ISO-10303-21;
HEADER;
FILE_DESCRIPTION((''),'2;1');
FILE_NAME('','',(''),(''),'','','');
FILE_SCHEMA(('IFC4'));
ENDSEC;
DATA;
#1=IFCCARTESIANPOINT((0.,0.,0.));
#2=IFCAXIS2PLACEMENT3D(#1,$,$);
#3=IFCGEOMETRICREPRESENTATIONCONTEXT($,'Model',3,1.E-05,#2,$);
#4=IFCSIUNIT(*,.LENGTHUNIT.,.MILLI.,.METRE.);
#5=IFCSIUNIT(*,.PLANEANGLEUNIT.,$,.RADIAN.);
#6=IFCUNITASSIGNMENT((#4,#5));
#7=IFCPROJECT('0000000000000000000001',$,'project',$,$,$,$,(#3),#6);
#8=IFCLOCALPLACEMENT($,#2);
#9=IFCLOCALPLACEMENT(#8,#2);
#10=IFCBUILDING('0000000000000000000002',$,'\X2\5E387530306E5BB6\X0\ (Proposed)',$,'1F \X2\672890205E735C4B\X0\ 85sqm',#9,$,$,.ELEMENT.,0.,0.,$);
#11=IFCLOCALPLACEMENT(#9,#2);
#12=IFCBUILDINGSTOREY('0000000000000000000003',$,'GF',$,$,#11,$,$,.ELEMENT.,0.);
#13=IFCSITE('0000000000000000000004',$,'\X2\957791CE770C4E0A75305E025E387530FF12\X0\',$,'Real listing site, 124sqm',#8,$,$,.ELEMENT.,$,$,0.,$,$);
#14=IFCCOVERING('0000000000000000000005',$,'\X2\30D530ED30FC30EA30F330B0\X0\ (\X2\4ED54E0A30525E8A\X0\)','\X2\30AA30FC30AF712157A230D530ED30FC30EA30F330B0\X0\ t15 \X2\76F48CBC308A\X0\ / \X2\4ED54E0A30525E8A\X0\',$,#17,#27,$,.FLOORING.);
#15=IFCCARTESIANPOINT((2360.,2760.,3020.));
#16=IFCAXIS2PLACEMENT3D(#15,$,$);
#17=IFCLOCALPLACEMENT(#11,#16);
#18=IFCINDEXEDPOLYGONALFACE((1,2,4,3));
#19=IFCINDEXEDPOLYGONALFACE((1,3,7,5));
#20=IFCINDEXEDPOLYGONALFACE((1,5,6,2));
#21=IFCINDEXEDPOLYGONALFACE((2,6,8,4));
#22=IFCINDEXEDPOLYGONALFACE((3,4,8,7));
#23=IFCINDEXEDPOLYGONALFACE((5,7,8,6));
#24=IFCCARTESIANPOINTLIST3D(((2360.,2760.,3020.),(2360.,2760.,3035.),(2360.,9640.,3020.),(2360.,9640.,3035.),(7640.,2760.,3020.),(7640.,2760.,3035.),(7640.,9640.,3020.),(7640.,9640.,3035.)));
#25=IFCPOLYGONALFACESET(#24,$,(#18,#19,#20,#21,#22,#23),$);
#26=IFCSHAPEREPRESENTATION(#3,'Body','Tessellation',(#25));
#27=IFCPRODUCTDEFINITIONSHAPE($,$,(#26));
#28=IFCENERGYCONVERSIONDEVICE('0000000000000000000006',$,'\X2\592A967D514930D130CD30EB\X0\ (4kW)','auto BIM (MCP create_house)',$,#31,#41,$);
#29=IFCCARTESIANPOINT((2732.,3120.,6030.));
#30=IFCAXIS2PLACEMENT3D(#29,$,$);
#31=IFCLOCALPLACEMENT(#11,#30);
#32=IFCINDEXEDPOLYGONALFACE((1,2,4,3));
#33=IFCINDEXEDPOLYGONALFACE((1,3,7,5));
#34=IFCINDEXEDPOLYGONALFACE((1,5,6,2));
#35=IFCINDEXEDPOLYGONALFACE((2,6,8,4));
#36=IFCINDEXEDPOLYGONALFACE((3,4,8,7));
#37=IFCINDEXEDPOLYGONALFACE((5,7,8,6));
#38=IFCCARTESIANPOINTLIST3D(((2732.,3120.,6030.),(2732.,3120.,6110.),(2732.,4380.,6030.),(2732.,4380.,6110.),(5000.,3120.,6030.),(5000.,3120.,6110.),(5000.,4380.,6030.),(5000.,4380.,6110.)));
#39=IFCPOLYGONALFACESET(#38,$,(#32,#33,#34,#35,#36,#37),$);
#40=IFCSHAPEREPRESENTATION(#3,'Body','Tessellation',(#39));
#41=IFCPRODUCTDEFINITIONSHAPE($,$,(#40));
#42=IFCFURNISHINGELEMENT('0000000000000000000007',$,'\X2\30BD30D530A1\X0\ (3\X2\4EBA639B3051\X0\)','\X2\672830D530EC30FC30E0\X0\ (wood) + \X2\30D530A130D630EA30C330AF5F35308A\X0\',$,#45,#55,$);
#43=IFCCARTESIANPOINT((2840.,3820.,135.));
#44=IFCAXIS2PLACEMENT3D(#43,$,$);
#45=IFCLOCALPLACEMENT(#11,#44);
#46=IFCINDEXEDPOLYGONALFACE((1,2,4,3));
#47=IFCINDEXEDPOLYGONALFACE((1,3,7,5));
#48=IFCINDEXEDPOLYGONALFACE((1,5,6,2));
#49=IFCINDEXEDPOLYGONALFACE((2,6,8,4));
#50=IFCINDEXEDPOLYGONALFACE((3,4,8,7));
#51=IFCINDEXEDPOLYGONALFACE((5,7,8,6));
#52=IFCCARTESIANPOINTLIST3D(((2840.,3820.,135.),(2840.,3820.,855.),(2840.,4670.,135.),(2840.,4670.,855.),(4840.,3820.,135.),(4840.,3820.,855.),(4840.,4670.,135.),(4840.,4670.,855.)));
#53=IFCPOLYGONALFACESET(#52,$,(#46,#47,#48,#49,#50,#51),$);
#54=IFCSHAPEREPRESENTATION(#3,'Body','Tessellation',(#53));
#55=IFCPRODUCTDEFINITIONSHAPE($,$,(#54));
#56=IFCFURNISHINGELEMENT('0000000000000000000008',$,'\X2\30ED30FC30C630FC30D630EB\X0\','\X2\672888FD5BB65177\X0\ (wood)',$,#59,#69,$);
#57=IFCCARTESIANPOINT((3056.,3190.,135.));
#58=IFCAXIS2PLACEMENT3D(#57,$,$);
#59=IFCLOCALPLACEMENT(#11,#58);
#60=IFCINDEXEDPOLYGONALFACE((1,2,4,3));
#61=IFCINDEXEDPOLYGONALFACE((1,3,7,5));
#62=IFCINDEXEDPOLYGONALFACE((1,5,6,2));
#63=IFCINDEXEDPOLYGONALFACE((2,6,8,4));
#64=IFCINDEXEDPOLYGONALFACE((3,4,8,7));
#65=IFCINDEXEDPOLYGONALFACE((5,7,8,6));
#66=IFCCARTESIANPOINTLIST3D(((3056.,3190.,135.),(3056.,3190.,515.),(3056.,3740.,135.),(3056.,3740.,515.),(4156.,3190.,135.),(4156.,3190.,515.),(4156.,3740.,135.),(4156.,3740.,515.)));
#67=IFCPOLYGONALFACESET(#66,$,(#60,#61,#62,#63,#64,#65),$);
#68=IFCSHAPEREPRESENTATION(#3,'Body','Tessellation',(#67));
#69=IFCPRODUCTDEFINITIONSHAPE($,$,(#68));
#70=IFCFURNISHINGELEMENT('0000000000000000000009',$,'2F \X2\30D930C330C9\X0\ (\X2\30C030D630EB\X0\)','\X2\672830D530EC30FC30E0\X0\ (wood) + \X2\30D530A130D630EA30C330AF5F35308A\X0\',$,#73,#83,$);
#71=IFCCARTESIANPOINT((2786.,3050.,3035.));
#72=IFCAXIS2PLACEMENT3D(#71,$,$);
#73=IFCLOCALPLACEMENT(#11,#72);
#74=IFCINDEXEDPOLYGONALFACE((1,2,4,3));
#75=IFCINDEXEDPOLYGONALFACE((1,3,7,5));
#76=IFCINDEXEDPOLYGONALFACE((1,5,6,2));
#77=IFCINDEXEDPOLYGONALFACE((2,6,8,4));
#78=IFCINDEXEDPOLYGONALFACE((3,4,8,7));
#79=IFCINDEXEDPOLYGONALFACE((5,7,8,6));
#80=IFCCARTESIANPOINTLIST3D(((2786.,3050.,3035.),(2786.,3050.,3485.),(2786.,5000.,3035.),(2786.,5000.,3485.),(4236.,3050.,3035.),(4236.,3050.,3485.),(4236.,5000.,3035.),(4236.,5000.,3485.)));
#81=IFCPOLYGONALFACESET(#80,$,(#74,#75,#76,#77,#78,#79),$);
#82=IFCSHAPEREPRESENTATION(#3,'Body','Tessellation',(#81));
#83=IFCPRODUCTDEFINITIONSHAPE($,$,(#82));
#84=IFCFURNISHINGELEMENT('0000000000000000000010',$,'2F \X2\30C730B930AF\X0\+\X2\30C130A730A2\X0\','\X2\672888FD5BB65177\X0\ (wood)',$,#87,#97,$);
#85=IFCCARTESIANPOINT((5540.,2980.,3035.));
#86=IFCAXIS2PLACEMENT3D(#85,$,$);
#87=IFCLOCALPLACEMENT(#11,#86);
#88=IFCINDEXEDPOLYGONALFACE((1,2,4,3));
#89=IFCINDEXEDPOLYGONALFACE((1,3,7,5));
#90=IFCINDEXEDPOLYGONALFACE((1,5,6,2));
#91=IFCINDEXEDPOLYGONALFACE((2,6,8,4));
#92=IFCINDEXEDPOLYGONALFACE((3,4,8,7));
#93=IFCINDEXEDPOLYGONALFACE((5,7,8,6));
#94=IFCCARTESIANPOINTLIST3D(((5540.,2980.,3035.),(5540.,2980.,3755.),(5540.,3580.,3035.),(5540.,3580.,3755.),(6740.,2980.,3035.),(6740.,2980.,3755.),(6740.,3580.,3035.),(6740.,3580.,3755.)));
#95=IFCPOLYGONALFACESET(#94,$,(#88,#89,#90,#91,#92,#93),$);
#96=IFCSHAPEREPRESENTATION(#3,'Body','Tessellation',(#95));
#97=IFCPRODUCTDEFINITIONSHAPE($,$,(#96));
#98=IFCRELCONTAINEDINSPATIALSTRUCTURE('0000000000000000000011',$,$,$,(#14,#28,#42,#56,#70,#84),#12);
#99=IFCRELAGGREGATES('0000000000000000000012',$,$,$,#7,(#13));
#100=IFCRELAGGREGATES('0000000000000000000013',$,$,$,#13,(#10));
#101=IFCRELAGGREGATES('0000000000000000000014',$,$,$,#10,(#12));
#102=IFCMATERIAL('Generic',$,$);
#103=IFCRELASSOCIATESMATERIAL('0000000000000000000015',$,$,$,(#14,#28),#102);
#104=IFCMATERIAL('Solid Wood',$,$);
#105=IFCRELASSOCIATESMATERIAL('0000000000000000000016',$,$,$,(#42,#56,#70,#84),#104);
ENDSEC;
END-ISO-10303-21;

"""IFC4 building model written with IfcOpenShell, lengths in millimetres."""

from ifc_helpers import new_model, si_unit, frame, frame_2d, origin, place, context, project, spatial, rectangle, extrude, material, element, save


model = new_model("IFC4")

# Units and contexts
model_context = context("Model", 3, precision=1e-05, world=origin())
ifc_project = project(units=[si_unit("LENGTHUNIT", "METRE", prefix="MILLI"), si_unit("PLANEANGLEUNIT", "RADIAN")], contexts=[model_context])

# Site, building, storey
site_placement = place(None, origin())
site = spatial("IfcSite", under=ifc_project, at=site_placement, Name="長野県上田市常田２", ObjectType="Real listing site, 124sqm", CompositionType="ELEMENT", RefElevation=0.0)
building_placement = place(site_placement, origin())
building = spatial("IfcBuilding", under=site, at=building_placement, Name="常田の家 (Proposed)", ObjectType="1F 木造平屋 85sqm", CompositionType="ELEMENT", ElevationOfRefHeight=0.0, ElevationOfTerrain=0.0)
storey_placement = place(building_placement, origin())
storey = spatial("IfcBuildingStorey", under=building, at=storey_placement, Name="GF", CompositionType="ELEMENT", Elevation=0.0)

# Shared definitions
ifc_material_1 = material(Name="Solid Wood")

# Shared definitions
ifc_material_2 = material(Name="Generic")

# Covering
covering_placement = place(storey_placement, frame((2360.0, 2760.0, 3020.0)))
element("IfcCovering", 1, at=covering_placement, inside=storey, material=ifc_material_2, Name="フローリング (仕上げ床)", Description="オーク無垢フローリング t15 直貼り / 仕上げ床", PredefinedType="FLOORING", context=model_context, shape_type="SweptSolid", body=[
    extrude(rectangle(XDim=5280.0, YDim=6880.0, at=frame_2d((2640.0, 3440.0))), frame((2360.0, 2760.0, 3020.0)), (0.0, 0.0, 1.0), 15.0),
])

# Energy conversion device
energy_conversion_device_placement = place(storey_placement, frame((2732.0, 3120.0, 6030.0)))
element("IfcEnergyConversionDevice", 2, at=energy_conversion_device_placement, inside=storey, material=ifc_material_2, Name="太陽光パネル (4kW)", Description="auto BIM (MCP create_house)", context=model_context, shape_type="SweptSolid", body=[
    extrude(rectangle(XDim=2268.0, YDim=1260.0, at=frame_2d((1134.0, 630.0))), frame((2732.0, 3120.0, 6030.0)), (0.0, 0.0, 1.0), 80.0),
])

# Furnishing elements
furnishing_1_placement = place(storey_placement, frame((2840.0, 3820.0, 135.0)))
element("IfcFurnishingElement", 3, at=furnishing_1_placement, inside=storey, material=ifc_material_1, Name="ソファ (3人掛け)", Description="木フレーム (wood) + ファブリック張り", context=model_context, shape_type="SweptSolid", body=[
    extrude(rectangle(XDim=2000.0, YDim=850.0, at=frame_2d((1000.0, 425.0))), frame((2840.0, 3820.0, 135.0)), (0.0, 0.0, 1.0), 720.0),
])
furnishing_2_placement = place(storey_placement, frame((3056.0, 3190.0, 135.0)))
element("IfcFurnishingElement", 4, at=furnishing_2_placement, inside=storey, material=ifc_material_1, Name="ローテーブル", Description="木製家具 (wood)", context=model_context, shape_type="SweptSolid", body=[
    extrude(rectangle(XDim=1100.0, YDim=550.0, at=frame_2d((550.0, 275.0))), frame((3056.0, 3190.0, 135.0)), (0.0, 0.0, 1.0), 380.0),
])
furnishing_3_placement = place(storey_placement, frame((2786.0, 3050.0, 3035.0)))
element("IfcFurnishingElement", 5, at=furnishing_3_placement, inside=storey, material=ifc_material_1, Name="2F ベッド (ダブル)", Description="木フレーム (wood) + ファブリック張り", context=model_context, shape_type="SweptSolid", body=[
    extrude(rectangle(XDim=1450.0, YDim=1950.0, at=frame_2d((725.0, 975.0))), frame((2786.0, 3050.0, 3035.0)), (0.0, 0.0, 1.0), 450.0),
])
furnishing_4_placement = place(storey_placement, frame((5540.0, 2980.0, 3035.0)))
element("IfcFurnishingElement", 6, at=furnishing_4_placement, inside=storey, material=ifc_material_1, Name="2F デスク+チェア", Description="木製家具 (wood)", context=model_context, shape_type="SweptSolid", body=[
    extrude(rectangle(XDim=1200.0, YDim=600.0, at=frame_2d((600.0, 300.0))), frame((5540.0, 2980.0, 3035.0)), (0.0, 0.0, 1.0), 720.0),
])

save(model, "model.ifc")
